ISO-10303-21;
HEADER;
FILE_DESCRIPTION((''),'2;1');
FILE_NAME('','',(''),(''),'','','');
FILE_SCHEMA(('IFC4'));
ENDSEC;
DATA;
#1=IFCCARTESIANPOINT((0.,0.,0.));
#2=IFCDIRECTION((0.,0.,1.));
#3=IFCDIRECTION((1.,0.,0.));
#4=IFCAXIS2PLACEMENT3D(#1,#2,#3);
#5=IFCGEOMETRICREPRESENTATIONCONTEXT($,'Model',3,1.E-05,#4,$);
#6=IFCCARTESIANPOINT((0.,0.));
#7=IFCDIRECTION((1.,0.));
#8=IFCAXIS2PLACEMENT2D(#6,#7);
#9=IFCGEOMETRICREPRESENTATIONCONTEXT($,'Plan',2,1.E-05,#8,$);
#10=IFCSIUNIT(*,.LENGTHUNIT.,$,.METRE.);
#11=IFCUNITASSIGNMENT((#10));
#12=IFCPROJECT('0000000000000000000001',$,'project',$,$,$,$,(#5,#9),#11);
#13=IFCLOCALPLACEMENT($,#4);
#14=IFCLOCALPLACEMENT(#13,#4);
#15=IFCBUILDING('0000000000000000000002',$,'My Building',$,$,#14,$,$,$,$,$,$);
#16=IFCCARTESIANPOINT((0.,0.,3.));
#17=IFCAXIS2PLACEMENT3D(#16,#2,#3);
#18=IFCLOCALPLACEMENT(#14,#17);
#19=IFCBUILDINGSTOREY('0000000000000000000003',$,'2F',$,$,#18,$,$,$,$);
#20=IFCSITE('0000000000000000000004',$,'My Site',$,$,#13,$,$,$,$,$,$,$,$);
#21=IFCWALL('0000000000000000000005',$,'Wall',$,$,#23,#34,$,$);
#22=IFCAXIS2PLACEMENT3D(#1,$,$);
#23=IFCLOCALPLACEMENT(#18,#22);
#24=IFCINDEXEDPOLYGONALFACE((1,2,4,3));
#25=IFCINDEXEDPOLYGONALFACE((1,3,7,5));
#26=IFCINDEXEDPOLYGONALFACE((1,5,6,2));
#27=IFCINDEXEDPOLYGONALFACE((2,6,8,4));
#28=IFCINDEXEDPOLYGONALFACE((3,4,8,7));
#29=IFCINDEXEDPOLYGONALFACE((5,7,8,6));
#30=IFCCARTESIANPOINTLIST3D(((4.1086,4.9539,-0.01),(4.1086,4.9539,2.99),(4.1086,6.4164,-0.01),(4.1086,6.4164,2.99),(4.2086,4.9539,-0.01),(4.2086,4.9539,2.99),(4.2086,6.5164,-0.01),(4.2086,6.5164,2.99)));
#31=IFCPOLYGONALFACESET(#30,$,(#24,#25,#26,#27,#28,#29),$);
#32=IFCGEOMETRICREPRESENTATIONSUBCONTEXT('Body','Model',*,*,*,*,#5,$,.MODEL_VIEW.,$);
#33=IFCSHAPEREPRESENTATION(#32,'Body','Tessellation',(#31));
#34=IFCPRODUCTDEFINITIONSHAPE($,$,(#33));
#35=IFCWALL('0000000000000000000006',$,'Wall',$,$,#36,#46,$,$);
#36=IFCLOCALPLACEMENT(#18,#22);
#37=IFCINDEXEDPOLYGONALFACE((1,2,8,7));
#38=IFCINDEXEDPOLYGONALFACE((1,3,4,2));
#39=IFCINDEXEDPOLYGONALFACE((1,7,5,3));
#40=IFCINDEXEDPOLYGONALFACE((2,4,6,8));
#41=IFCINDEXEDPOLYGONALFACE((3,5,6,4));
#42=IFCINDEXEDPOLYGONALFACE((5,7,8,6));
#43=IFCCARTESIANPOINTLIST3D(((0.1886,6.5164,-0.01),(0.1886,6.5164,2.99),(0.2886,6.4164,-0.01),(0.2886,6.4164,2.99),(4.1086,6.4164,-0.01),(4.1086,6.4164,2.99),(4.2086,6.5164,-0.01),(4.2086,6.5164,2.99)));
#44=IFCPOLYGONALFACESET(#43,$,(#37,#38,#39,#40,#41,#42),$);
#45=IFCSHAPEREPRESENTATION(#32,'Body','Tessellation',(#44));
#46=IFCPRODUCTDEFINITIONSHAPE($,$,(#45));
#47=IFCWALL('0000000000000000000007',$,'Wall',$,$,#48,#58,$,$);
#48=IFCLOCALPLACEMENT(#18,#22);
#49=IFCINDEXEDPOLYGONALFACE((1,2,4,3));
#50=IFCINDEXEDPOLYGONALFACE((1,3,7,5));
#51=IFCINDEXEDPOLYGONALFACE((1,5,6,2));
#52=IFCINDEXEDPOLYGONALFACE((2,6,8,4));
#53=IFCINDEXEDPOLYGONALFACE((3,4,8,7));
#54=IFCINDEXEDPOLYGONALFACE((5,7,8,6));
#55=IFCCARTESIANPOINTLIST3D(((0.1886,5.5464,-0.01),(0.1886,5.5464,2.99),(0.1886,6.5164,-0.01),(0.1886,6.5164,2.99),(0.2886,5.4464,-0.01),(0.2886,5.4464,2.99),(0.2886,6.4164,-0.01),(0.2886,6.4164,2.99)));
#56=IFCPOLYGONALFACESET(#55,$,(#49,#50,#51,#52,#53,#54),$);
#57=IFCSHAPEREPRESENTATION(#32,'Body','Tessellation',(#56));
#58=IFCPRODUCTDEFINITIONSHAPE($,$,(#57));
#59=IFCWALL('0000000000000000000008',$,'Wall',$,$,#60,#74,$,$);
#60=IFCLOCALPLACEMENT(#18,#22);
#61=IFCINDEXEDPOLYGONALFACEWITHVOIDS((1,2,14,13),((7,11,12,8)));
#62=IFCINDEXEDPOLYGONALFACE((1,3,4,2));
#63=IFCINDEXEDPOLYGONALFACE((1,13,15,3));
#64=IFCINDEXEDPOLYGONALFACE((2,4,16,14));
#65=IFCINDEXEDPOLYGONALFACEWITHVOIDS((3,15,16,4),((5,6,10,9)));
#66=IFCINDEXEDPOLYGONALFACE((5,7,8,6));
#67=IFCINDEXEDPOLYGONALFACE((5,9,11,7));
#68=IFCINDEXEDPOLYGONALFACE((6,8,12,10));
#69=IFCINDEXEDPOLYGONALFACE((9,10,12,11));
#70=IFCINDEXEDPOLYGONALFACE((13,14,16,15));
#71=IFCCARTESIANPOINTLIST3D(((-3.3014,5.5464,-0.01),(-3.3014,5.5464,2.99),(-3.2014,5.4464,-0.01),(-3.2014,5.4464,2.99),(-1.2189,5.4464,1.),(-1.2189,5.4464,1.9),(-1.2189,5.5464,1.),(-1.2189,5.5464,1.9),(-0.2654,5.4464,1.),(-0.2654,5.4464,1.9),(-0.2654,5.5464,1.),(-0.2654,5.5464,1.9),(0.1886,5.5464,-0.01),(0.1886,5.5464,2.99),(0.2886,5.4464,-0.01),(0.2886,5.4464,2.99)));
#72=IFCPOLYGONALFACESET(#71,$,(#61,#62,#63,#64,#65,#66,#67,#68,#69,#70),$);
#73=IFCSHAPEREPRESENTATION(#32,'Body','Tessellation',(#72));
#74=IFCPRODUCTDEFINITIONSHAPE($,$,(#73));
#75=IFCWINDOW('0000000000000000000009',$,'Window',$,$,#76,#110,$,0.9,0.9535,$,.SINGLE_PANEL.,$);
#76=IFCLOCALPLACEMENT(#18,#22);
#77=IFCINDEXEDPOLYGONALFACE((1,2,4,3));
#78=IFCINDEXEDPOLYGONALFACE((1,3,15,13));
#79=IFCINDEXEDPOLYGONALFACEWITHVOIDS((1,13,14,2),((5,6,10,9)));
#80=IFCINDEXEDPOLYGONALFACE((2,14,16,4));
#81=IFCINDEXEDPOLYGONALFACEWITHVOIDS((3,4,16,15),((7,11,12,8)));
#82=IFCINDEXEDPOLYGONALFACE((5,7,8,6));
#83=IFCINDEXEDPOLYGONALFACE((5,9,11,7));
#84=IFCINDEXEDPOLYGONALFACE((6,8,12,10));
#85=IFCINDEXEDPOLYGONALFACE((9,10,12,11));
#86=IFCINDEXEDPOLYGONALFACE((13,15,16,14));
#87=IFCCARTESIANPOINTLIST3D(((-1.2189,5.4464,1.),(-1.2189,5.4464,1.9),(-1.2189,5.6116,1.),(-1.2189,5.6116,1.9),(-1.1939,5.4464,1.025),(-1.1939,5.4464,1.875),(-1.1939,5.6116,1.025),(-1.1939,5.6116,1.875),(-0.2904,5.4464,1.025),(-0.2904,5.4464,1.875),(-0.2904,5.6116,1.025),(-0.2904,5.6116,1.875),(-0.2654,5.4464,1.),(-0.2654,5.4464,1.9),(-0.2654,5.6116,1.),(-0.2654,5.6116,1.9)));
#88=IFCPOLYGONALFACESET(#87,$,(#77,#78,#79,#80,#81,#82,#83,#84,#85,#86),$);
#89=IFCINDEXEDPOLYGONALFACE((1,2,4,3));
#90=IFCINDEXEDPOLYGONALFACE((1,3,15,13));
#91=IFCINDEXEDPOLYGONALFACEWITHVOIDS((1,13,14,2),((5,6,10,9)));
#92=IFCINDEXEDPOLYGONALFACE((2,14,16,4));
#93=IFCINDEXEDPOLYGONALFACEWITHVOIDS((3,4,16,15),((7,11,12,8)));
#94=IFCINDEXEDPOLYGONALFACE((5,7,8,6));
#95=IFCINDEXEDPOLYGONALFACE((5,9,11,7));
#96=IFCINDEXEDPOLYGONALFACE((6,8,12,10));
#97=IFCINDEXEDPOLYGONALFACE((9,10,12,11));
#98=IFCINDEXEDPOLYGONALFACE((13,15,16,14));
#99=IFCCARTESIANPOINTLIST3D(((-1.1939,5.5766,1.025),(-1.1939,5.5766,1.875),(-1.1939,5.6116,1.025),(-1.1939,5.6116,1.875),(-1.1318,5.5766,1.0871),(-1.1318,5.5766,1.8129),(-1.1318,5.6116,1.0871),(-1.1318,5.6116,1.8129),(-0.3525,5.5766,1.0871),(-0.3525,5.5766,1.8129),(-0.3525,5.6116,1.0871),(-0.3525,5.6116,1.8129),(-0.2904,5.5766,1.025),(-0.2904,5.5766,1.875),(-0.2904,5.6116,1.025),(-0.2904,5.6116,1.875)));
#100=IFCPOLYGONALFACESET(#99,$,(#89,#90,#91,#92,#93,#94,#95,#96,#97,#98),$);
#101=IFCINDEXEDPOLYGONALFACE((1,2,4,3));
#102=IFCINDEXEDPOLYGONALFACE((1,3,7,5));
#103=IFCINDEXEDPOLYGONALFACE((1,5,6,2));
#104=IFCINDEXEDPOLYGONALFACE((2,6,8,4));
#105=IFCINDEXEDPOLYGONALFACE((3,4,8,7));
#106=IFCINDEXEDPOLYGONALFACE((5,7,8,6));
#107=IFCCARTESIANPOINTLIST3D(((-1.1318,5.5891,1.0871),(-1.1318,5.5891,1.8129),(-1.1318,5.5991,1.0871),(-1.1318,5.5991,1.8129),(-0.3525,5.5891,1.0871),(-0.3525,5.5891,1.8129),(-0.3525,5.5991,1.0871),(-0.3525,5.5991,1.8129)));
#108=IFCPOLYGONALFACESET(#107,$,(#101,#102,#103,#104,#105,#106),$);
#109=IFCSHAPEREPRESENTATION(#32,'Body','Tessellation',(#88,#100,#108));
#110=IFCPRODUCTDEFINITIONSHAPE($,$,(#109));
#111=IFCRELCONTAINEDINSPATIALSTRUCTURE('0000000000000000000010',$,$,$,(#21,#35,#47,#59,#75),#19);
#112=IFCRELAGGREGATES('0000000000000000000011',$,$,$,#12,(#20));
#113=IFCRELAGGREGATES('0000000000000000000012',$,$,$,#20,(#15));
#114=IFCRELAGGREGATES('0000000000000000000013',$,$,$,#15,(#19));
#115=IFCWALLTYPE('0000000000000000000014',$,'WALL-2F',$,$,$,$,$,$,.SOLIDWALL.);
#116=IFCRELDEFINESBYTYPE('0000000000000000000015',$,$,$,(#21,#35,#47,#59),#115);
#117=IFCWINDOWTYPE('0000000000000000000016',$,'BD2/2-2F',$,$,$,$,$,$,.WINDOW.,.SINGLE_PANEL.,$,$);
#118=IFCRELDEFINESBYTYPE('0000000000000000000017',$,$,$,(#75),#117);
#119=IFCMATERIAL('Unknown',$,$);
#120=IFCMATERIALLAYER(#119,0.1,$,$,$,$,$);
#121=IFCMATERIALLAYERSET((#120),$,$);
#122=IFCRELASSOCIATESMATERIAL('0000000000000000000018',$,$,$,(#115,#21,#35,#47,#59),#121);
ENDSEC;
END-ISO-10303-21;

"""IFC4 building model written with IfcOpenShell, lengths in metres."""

from ifc_helpers import new_model, entity, si_unit, frame, origin_with_axes, origin_2d_with_axis, place, context, subcontext, project, spatial, line, indexed_curve, outline, extrude, shape, source, transform, mapped, material, layer, layer_set, layer_usage, type_object, type_shapes, element, fill, save


model = new_model("IFC4")

# Units and contexts
model_context = context("Model", 3, precision=1e-05, world=origin_with_axes())
plan_context = context("Plan", 2, precision=1e-05, world=origin_2d_with_axis())
body_context_1 = subcontext(model_context, "Body", "Model", "MODEL_VIEW")
body_context_2 = subcontext(plan_context, "Body", "Plan", "PLAN_VIEW")
ifc_project = project(units=[si_unit("LENGTHUNIT", "METRE")], contexts=[model_context, plan_context])

# Site, building, storey
site_placement = place(None, origin_with_axes())
site = spatial("IfcSite", under=ifc_project, at=site_placement, Name="My Site")
building_placement = place(site_placement, origin_with_axes())
building = spatial("IfcBuilding", under=site, at=building_placement, Name="My Building")
storey_placement = place(building_placement, frame((0.0, 0.0, 3.0), z_axis=(0.0, 0.0, 1.0), x_axis=(1.0, 0.0, 0.0)))
storey = spatial("IfcBuildingStorey", under=building, at=storey_placement, Name="2F")

# Shared definitions
ifc_material_1 = material(Name="Unknown")

# Walls
ifc_layer_1 = layer(ifc_material_1, 0.1)
ifc_layer_set_1 = layer_set([ifc_layer_1])
wall_type_1 = type_object("IfcWallType", Name="WALL-2F", PredefinedType="SOLIDWALL", material=ifc_layer_set_1)
ifc_layer_usage_1 = layer_usage(ifc_layer_set_1, "AXIS2", "POSITIVE", 0.0)
wall_1_placement = place(storey_placement, frame((4.2086, 4.9539, -0.01), z_axis=(0.0, 0.0, 1.0), x_axis=(0.0, 1.0, 0.0)))
element("IfcWall", 1, at=wall_1_placement, inside=storey, type_object=wall_type_1, material=ifc_layer_usage_1, Name="Wall", context=body_context_1, shape_type="SweptSolid", body=[
    extrude(outline(indexed_curve([(0.0, 0.0), (0.0, 0.1), (1.4626, 0.1), (1.5626, 0.0)], segments=[line(1, 2, 3, 4, 1)])), origin_with_axes(), (0.0, 0.0, 1.0), 3.0),
])
ifc_layer_usage_2 = layer_usage(ifc_layer_set_1, "AXIS2", "POSITIVE", 0.0)
wall_2_placement = place(storey_placement, frame((4.2086, 6.5164, -0.01), z_axis=(0.0, 0.0, 1.0), x_axis=(-1.0, 0.0, 0.0)))
element("IfcWall", 2, at=wall_2_placement, inside=storey, type_object=wall_type_1, material=ifc_layer_usage_2, Name="Wall", context=body_context_1, shape_type="SweptSolid", body=[
    extrude(outline(indexed_curve([(0.0, 0.0), (0.1, 0.1), (3.92, 0.1), (4.02, 0.0)], segments=[line(1, 2, 3, 4, 1)])), origin_with_axes(), (0.0, 0.0, 1.0), 3.0),
])
ifc_layer_usage_3 = layer_usage(ifc_layer_set_1, "AXIS2", "POSITIVE", 0.0)
wall_3_placement = place(storey_placement, frame((0.1886, 6.5164, -0.01), z_axis=(0.0, 0.0, 1.0), x_axis=(0.0, -1.0, 0.0)))
element("IfcWall", 3, at=wall_3_placement, inside=storey, type_object=wall_type_1, material=ifc_layer_usage_3, Name="Wall", context=body_context_1, shape_type="SweptSolid", body=[
    extrude(outline(indexed_curve([(0.0, 0.0), (0.1, 0.1), (1.07, 0.1), (0.97, 0.0)], segments=[line(1, 2, 3, 4, 1)])), origin_with_axes(), (0.0, 0.0, 1.0), 3.0),
])

# Wall, opening, window
ifc_layer_usage_4 = layer_usage(ifc_layer_set_1, "AXIS2", "POSITIVE", 0.0)
wall_4_placement = place(storey_placement, frame((0.1886, 5.5464, -0.01), z_axis=(0.0, 0.0, 1.0), x_axis=(-1.0, 0.0, 0.0)))
wall_4 = element("IfcWall", 4, at=wall_4_placement, inside=storey, type_object=wall_type_1, material=ifc_layer_usage_4, Name="Wall", context=body_context_1, shape_type="SweptSolid", body=[
    extrude(outline(indexed_curve([(0.0, 0.0), (-0.1, 0.1), (3.39, 0.1), (3.49, 0.0)], segments=[line(1, 2, 3, 4, 1)])), origin_with_axes(), (0.0, 0.0, 1.0), 3.0),
])
shared_shape_1 = source(origin_with_axes(), body_context_1, "Body", "SweptSolid", [
    extrude(outline(indexed_curve([(0.0, 0.0), (0.9535, 0.0), (0.9535, 0.9), (0.0, 0.9)], segments=[line(1, 2, 3, 4, 1)])), frame((0.0, -0.6, 0.0), z_axis=(0.0, -1.0, 0.0), x_axis=(1.0, 0.0, 0.0)), (0.0, 0.0, -1.0), 1.2),
])
opening_1_placement = place(wall_4_placement, frame((0.454, 0.0, 1.01), z_axis=(0.0, 0.0, 1.0), x_axis=(1.0, 0.0, 0.0)))
opening_1 = element("IfcOpeningElement", 5, at=opening_1_placement, cuts=wall_4, PredefinedType="OPENING", context=body_context_1, shape_type="MappedRepresentation", body=[
    mapped(shared_shape_1, transform((0.0, 0.0, 0.0), x_axis=(1.0, 0.0, 0.0), y_axis=(0.0, 1.0, 0.0), z_axis=(0.0, 0.0, 1.0), scale=1.0)),
])
window_type_1 = type_object("IfcWindowType", Name="BD2/2-2F", PartitioningType="SINGLE_PANEL", PredefinedType="WINDOW")
shared_shape_2 = source(origin_with_axes(), body_context_1, "Body", "SweptSolid", [
    extrude(outline(indexed_curve([(0.0, 0.0), (0.9535, 0.0), (0.9535, 0.9), (0.0, 0.9)], segments=[line(1, 2, 3, 4, 1)]), holes=[indexed_curve([(0.025, 0.025), (0.9285, 0.025), (0.9285, 0.875), (0.025, 0.875)], segments=[line(1, 2, 3, 4, 1)])]), frame((0.0, -0.0651, 0.0), z_axis=(0.0, -1.0, 0.0), x_axis=(1.0, 0.0, 0.0)), (0.0, 0.0, -1.0), 0.1651),
    extrude(outline(indexed_curve([(0.0, 0.0), (0.9535, 0.0), (0.9535, 0.9), (0.0, 0.9)], segments=[line(1, 2, 3, 4, 1)]), holes=[indexed_curve([(0.708, 0.708), (0.2455, 0.708), (0.2455, 0.192), (0.708, 0.192)], segments=[line(1, 2, 3, 4, 1)])]), frame((0.0, 0.05, 0.0), z_axis=(0.0, -1.0, 0.0), x_axis=(1.0, 0.0, 0.0)), (0.0, 0.0, -1.0), -0.1151),
    extrude(outline(indexed_curve([(0.0, 0.0), (0.9035, 0.0), (0.9035, 0.85), (0.0, 0.85)], segments=[line(1, 2, 3, 4, 1)]), holes=[indexed_curve([(0.0621, 0.0621), (0.8414, 0.0621), (0.8414, 0.7879), (0.0621, 0.7879)], segments=[line(1, 2, 3, 4, 1)])]), frame((0.025, -0.0651, 0.025), z_axis=(0.0, -1.0, 0.0), x_axis=(1.0, 0.0, 0.0)), (0.0, 0.0, -1.0), 0.035),
    extrude(outline(indexed_curve([(0.0621, 0.0621), (0.8414, 0.0621), (0.8414, 0.7879), (0.0621, 0.7879)], segments=[line(1, 2, 3, 4, 1)])), frame((0.025, -0.0526, 0.025), z_axis=(0.0, -1.0, 0.0), x_axis=(1.0, 0.0, 0.0)), (0.0, 0.0, -1.0), 0.01),
])
shared_shape_3 = source(origin_with_axes(), body_context_2, "Body", "Curve2D", [
    entity("IfcIndexedPolyCurve", entity("IfcCartesianPointList2D", [[0.708, 0.05], [0.2455, 0.05]])),
    entity("IfcIndexedPolyCurve", entity("IfcCartesianPointList2D", [[0.0, 0.1], [0.025, 0.1], [0.025, -0.0651], [0.708, -0.0651], [0.708, 0.05], [0.0, 0.05]]), [entity("IfcLineIndex", [1, 2, 3, 4, 5, 6, 1])]),
    entity("IfcIndexedPolyCurve", entity("IfcCartesianPointList2D", [[0.9535, 0.1], [0.9285, 0.1], [0.9285, -0.0651], [0.2455, -0.0651], [0.2455, 0.05], [0.9535, 0.05]]), [entity("IfcLineIndex", [1, 2, 3, 4, 5, 6, 1])]),
    entity("IfcIndexedPolyCurve", entity("IfcCartesianPointList2D", [[0.025, -0.0651], [0.0871, -0.0651], [0.0871, -0.0301], [0.025, -0.0301]]), [entity("IfcLineIndex", [1, 2, 3, 4, 1])]),
    entity("IfcIndexedPolyCurve", entity("IfcCartesianPointList2D", [[0.9285, -0.0651], [0.8664, -0.0651], [0.8664, -0.0301], [0.9285, -0.0301]]), [entity("IfcLineIndex", [1, 2, 3, 4, 1])]),
    entity("IfcIndexedPolyCurve", entity("IfcCartesianPointList2D", [[0.0871, -0.0651], [0.8664, -0.0651]])),
    entity("IfcIndexedPolyCurve", entity("IfcCartesianPointList2D", [[0.0871, -0.0301], [0.8664, -0.0301]])),
    entity("IfcIndexedPolyCurve", entity("IfcCartesianPointList2D", [[0.0871, -0.0476], [0.8664, -0.0476]])),
])
type_shapes(window_type_1, [shared_shape_2, shared_shape_3])
window_1_placement = place(opening_1_placement, frame((0.0, 0.0, 0.0), z_axis=(0.0, 0.0, 1.0), x_axis=(1.0, 0.0, 0.0)))
window_1 = element("IfcWindow", 6, at=window_1_placement, inside=storey, type_object=window_type_1, Name="Window", OverallHeight=0.9, OverallWidth=0.9535, PartitioningType="SINGLE_PANEL", shapes=[
    shape(body_context_1, "Body", "MappedRepresentation", [mapped(shared_shape_2, transform((0.0, 0.0, 0.0), x_axis=(1.0, 0.0, 0.0), y_axis=(0.0, 1.0, 0.0), z_axis=(0.0, 0.0, 1.0), scale=1.0))]),
    shape(body_context_2, "Body", "MappedRepresentation", [mapped(shared_shape_3, transform((0.0, 0.0, 0.0), x_axis=(1.0, 0.0, 0.0), y_axis=(0.0, 1.0, 0.0), z_axis=(0.0, 0.0, 1.0), scale=1.0))]),
])
fill(opening_1, window_1)

save(model, "model.ifc")
